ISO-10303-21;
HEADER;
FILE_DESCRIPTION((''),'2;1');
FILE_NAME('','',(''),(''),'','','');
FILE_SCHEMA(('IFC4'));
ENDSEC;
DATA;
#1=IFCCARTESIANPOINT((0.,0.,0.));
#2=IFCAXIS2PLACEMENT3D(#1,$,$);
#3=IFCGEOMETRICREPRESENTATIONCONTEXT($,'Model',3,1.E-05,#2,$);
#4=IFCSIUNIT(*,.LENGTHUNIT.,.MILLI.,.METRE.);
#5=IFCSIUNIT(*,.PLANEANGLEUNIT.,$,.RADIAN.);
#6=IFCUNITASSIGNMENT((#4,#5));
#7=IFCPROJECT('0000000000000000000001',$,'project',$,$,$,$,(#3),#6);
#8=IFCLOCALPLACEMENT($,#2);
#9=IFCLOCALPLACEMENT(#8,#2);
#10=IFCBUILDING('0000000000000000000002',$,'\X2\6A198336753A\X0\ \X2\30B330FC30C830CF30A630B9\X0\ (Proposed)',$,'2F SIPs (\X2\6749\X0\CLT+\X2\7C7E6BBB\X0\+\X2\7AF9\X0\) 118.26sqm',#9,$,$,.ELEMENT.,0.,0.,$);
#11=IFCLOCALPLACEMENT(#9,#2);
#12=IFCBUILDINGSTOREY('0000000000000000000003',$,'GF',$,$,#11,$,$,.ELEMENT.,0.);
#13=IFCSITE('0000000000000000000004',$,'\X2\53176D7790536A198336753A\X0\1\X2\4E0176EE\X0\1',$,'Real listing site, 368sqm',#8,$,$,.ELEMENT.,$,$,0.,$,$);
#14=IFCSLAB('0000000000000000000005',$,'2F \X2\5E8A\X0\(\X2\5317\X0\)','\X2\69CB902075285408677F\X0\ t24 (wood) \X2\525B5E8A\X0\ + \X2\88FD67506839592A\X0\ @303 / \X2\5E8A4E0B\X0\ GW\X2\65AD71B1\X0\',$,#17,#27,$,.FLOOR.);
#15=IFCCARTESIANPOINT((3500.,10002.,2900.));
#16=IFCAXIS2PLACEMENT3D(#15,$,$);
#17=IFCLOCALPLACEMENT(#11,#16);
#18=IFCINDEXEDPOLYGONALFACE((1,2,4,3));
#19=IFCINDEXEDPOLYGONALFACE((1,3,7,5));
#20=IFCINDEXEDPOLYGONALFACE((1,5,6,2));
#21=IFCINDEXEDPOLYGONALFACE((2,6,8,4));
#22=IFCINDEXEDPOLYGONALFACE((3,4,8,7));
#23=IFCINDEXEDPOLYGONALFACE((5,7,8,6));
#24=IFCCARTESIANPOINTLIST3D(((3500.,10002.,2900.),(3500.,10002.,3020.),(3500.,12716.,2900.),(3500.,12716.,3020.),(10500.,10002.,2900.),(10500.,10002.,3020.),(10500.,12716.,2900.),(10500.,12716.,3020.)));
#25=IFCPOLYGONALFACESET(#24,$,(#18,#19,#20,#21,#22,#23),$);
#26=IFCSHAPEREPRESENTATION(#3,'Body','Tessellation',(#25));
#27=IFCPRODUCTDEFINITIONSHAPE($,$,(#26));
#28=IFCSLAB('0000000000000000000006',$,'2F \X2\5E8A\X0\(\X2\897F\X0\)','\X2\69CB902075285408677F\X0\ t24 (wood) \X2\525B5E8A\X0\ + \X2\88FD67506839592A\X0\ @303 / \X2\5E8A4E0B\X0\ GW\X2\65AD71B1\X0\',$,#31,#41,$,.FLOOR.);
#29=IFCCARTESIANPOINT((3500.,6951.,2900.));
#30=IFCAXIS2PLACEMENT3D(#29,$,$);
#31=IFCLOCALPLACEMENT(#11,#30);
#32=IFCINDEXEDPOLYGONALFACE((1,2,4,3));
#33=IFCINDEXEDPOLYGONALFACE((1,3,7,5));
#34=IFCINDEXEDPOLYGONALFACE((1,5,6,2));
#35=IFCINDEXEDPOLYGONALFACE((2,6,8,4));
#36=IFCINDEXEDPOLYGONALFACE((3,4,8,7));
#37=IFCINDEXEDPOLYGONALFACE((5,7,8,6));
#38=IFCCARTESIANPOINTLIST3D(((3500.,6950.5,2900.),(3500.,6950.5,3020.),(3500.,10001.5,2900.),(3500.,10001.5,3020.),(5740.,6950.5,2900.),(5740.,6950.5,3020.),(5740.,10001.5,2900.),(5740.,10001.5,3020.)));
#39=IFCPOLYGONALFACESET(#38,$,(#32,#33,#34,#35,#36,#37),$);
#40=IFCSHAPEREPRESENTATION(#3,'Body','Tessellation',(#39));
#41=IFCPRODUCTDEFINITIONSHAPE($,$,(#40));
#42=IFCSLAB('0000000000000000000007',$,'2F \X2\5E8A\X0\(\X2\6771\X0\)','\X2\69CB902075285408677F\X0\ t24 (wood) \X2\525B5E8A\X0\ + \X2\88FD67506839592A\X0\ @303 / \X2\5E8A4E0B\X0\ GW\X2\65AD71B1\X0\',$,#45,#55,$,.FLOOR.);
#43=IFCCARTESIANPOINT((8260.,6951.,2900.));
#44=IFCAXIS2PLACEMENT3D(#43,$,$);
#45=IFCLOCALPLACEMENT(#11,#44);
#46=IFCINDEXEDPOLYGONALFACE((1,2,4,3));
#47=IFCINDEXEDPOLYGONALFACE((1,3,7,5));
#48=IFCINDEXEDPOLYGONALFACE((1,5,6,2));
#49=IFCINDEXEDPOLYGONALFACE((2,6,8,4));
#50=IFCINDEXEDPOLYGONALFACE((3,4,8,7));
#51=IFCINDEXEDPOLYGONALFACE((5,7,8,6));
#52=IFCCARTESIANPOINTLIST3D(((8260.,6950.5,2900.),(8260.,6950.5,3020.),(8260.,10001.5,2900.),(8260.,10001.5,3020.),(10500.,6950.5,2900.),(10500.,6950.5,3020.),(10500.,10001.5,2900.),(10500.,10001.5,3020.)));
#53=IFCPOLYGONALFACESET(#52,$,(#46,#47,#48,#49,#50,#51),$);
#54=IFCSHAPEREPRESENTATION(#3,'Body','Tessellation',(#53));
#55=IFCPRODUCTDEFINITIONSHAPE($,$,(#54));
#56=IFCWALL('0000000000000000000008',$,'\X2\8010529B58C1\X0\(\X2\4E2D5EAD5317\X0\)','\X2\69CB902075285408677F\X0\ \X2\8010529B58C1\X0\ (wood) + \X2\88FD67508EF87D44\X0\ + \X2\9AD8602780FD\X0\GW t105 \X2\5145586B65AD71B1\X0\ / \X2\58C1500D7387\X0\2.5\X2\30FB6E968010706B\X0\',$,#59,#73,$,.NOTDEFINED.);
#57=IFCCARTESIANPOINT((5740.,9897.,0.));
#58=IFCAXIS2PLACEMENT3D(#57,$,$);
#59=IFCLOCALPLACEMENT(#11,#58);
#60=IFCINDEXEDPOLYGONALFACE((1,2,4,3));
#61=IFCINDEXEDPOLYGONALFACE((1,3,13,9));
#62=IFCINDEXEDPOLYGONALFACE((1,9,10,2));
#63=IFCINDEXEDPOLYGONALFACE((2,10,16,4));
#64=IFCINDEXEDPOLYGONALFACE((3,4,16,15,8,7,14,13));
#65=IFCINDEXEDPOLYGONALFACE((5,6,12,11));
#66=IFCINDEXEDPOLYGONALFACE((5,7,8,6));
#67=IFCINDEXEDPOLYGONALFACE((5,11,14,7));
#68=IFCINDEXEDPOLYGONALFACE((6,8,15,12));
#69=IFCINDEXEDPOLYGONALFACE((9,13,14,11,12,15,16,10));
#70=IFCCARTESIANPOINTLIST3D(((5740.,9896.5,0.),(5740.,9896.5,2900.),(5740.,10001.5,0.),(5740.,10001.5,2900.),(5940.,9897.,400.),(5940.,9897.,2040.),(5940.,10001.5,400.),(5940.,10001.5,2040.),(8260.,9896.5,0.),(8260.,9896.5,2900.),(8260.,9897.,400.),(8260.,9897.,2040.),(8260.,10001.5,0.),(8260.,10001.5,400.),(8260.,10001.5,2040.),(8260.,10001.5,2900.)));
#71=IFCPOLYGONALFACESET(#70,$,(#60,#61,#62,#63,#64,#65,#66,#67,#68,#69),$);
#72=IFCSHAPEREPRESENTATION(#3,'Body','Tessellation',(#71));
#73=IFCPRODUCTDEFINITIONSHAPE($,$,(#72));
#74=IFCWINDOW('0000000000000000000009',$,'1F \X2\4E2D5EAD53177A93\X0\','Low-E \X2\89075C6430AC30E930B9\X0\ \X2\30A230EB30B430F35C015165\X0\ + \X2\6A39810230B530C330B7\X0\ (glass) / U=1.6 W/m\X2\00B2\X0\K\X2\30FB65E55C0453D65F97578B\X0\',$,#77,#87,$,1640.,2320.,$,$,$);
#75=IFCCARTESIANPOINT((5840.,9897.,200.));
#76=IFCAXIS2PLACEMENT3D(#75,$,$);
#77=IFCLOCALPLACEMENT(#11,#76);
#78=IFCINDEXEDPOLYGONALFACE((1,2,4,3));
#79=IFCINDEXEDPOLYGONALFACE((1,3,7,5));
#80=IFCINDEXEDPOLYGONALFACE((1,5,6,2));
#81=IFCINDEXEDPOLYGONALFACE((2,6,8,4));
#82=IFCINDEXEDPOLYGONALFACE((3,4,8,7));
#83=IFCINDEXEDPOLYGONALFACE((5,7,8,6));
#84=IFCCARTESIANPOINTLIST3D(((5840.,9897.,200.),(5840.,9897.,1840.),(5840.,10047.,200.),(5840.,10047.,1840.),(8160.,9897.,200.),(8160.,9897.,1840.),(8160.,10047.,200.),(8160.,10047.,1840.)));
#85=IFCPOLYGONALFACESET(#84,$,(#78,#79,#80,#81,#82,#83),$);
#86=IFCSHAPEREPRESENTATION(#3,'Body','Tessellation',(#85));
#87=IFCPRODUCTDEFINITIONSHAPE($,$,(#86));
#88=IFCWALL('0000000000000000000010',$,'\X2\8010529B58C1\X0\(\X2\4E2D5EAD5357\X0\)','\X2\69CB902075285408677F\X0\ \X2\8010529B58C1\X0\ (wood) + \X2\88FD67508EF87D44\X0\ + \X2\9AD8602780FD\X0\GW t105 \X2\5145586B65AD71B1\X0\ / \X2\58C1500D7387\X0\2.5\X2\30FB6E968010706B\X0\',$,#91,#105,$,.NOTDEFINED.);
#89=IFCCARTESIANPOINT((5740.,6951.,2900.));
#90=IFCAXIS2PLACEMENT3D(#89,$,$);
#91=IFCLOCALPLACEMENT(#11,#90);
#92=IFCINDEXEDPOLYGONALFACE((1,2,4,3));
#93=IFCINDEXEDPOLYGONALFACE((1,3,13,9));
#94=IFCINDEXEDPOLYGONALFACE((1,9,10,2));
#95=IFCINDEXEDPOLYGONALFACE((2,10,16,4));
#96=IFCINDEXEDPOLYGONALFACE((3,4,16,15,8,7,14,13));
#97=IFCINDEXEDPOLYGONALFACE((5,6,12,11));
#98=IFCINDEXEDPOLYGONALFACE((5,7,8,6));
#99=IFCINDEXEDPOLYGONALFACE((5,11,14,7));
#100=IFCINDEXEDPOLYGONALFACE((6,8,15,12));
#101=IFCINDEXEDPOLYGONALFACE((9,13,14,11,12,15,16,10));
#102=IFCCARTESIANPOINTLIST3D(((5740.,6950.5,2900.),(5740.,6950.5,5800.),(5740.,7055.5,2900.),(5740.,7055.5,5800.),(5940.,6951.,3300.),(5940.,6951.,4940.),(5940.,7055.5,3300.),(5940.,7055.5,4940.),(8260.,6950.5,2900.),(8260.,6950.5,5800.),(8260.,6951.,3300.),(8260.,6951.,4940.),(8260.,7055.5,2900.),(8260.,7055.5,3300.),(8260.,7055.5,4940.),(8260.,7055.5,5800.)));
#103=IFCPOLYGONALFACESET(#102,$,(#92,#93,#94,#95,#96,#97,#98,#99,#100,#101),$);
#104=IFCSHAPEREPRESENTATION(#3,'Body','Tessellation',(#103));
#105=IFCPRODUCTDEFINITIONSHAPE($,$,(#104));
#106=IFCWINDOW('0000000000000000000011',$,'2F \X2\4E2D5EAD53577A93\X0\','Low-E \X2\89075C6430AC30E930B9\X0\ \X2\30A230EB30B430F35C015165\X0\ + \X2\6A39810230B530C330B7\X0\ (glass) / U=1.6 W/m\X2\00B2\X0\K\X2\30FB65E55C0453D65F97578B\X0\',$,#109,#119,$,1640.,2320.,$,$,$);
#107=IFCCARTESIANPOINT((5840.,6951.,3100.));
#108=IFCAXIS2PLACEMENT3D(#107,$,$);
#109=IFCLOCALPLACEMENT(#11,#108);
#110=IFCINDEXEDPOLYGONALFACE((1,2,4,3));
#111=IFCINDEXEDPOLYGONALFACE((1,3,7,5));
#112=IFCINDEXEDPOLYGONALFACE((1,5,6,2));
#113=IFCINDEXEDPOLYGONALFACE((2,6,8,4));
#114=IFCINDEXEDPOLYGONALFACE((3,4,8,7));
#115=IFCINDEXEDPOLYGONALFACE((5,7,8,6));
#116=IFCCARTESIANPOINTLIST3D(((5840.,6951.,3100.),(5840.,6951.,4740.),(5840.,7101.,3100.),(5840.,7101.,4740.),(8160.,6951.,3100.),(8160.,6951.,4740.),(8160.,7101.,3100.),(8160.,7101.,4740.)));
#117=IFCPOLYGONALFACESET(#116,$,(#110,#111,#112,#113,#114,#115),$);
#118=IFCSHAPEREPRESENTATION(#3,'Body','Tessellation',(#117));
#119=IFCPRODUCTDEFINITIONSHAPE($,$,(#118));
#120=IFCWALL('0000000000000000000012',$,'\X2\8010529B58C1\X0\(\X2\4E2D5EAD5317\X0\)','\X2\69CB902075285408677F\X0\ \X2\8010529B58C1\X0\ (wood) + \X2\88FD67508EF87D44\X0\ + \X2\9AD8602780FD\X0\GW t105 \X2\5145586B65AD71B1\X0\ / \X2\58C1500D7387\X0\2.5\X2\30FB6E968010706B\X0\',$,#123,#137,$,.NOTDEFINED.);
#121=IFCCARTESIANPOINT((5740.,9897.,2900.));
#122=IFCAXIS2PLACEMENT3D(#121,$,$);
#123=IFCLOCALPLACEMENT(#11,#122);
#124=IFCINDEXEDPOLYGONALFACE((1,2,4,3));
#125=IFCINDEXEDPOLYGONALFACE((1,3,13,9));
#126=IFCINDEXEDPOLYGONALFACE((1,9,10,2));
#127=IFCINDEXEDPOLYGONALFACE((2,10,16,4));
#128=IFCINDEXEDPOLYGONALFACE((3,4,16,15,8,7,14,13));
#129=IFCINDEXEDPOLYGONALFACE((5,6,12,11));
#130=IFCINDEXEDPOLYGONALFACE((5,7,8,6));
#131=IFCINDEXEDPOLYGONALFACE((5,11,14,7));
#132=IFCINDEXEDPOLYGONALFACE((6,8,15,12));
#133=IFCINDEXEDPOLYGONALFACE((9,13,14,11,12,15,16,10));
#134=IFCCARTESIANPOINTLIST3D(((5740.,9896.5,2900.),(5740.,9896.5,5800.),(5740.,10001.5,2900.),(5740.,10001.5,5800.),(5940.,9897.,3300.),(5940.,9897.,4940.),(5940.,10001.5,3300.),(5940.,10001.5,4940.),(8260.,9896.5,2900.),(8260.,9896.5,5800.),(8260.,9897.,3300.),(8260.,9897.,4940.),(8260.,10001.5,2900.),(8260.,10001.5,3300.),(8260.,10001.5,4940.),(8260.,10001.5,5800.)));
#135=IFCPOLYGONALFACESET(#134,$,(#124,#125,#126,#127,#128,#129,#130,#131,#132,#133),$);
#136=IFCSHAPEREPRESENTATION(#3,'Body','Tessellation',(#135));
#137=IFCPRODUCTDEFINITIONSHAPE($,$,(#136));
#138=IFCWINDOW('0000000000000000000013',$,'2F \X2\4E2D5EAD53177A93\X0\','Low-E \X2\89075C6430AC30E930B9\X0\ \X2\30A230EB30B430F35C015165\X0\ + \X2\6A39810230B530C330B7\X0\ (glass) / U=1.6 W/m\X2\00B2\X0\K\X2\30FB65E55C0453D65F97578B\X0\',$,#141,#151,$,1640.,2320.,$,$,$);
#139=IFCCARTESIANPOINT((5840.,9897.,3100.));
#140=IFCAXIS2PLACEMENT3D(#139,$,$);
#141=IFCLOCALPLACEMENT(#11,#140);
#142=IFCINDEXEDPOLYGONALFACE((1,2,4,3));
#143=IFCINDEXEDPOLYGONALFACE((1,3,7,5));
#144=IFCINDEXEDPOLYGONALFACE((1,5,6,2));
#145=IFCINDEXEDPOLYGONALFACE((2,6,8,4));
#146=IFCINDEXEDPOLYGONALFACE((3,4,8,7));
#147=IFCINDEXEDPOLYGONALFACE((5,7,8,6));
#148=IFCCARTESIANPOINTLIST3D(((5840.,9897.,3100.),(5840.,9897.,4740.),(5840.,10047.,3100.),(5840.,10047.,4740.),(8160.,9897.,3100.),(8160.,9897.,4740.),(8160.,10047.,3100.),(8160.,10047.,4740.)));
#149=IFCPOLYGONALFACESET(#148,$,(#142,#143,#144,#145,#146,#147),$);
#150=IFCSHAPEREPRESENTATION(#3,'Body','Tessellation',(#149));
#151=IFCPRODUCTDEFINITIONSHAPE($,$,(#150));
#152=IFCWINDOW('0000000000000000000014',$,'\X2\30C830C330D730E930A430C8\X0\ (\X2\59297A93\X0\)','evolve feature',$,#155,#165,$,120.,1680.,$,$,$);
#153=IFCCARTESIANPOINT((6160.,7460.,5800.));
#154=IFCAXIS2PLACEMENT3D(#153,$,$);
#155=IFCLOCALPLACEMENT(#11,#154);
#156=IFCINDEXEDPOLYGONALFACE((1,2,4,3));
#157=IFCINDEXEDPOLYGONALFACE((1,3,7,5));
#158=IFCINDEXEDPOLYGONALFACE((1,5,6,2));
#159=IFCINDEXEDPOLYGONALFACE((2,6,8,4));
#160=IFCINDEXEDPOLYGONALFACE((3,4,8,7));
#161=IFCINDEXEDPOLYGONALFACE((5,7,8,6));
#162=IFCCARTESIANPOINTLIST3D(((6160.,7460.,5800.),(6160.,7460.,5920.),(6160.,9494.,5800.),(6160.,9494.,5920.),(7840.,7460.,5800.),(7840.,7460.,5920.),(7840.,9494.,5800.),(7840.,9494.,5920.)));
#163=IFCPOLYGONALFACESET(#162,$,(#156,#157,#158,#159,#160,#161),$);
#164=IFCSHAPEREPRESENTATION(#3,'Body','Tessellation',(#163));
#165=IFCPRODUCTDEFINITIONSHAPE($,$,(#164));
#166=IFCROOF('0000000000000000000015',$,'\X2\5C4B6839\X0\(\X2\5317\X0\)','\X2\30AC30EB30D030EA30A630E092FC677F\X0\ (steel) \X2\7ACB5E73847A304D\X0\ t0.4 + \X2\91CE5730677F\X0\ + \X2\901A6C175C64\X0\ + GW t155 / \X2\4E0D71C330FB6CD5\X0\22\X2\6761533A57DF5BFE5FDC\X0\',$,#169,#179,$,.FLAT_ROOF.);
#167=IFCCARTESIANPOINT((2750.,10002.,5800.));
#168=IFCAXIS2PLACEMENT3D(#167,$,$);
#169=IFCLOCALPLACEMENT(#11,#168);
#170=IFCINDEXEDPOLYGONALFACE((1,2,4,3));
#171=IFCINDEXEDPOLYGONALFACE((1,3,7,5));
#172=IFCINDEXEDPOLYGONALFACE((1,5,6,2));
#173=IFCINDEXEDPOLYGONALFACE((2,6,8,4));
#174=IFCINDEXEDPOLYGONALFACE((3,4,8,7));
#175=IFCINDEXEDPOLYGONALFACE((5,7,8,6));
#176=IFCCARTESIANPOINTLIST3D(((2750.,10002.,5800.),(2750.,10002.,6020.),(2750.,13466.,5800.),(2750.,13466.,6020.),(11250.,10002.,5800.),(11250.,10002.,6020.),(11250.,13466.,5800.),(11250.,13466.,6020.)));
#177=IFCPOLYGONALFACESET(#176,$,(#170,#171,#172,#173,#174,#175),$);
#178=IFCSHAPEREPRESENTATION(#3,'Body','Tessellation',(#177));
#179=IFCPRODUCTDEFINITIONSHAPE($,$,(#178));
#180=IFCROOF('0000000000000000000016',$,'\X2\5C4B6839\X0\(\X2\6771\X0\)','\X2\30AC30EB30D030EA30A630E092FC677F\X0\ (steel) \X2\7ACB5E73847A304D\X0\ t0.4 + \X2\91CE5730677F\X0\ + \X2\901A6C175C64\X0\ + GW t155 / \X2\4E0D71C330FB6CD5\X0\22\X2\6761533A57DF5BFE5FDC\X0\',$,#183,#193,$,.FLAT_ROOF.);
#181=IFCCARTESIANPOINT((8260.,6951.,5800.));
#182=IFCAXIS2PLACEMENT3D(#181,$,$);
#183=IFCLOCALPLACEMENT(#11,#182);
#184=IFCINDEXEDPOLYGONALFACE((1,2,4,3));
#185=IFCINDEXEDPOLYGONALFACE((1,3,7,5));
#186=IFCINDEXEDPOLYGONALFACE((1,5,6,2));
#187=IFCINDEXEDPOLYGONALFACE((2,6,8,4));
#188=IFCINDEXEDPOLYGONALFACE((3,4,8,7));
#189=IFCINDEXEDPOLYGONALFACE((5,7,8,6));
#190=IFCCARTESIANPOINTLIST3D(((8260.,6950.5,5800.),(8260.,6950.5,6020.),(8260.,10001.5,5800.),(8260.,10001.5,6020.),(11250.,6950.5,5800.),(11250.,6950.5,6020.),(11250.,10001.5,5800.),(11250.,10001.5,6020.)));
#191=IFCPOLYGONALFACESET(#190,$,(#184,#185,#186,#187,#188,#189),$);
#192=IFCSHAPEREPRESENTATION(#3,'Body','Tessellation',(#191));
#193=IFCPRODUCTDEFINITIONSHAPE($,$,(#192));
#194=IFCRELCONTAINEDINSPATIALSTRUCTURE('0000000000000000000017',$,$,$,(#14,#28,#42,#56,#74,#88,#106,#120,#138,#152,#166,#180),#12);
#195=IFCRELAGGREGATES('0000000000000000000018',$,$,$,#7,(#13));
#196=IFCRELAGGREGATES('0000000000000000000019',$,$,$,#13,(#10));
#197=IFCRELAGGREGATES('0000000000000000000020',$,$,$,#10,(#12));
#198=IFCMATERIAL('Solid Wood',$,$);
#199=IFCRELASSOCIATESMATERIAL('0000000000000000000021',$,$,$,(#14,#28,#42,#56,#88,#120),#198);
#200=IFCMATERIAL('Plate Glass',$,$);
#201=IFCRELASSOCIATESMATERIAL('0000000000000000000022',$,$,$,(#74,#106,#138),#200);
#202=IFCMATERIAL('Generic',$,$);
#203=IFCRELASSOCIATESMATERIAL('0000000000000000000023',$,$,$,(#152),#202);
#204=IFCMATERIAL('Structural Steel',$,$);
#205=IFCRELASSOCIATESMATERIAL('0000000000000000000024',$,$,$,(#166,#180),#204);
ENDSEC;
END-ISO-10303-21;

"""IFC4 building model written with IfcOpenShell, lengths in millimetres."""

from ifc_helpers import new_model, si_unit, frame, frame_2d, origin, place, context, project, spatial, rectangle, extrude, material, element, fill, save


model = new_model("IFC4")

# Units and contexts
model_context = context("Model", 3, precision=1e-05, world=origin())
ifc_project = project(units=[si_unit("LENGTHUNIT", "METRE", prefix="MILLI"), si_unit("PLANEANGLEUNIT", "RADIAN")], contexts=[model_context])

# Site, building, storey
site_placement = place(None, origin())
site = spatial("IfcSite", under=ifc_project, at=site_placement, Name="北海道標茶町1丁目1", ObjectType="Real listing site, 368sqm", CompositionType="ELEMENT", RefElevation=0.0)
building_placement = place(site_placement, origin())
building = spatial("IfcBuilding", under=site, at=building_placement, Name="標茶町 コートハウス (Proposed)", ObjectType="2F SIPs (杉CLT+籾殻+竹) 118.26sqm", CompositionType="ELEMENT", ElevationOfRefHeight=0.0, ElevationOfTerrain=0.0)
storey_placement = place(building_placement, origin())
storey = spatial("IfcBuildingStorey", under=building, at=storey_placement, Name="GF", CompositionType="ELEMENT", Elevation=0.0)

# Slabs
ifc_material_1 = material(Name="Solid Wood")
slab_1_placement = place(storey_placement, frame((3500.0, 10002.0, 2900.0)))
element("IfcSlab", 1, at=slab_1_placement, inside=storey, material=ifc_material_1, Name="2F 床(北)", Description="構造用合板 t24 (wood) 剛床 + 製材根太 @303 / 床下 GW断熱", PredefinedType="FLOOR", context=model_context, shape_type="SweptSolid", body=[
    extrude(rectangle(XDim=7000.0, YDim=2714.0, at=frame_2d((3500.0, 1357.0))), frame((3500.0, 10002.0, 2900.0)), (0.0, 0.0, 1.0), 120.0),
])
slab_2_placement = place(storey_placement, frame((3500.0, 6951.0, 2900.0)))
element("IfcSlab", 2, at=slab_2_placement, inside=storey, material=ifc_material_1, Name="2F 床(西)", Description="構造用合板 t24 (wood) 剛床 + 製材根太 @303 / 床下 GW断熱", PredefinedType="FLOOR", context=model_context, shape_type="SweptSolid", body=[
    extrude(rectangle(XDim=2240.0, YDim=3051.0, at=frame_2d((1120.0, 1525.0))), frame((3500.0, 6951.0, 2900.0)), (0.0, 0.0, 1.0), 120.0),
])
slab_3_placement = place(storey_placement, frame((8260.0, 6951.0, 2900.0)))
element("IfcSlab", 3, at=slab_3_placement, inside=storey, material=ifc_material_1, Name="2F 床(東)", Description="構造用合板 t24 (wood) 剛床 + 製材根太 @303 / 床下 GW断熱", PredefinedType="FLOOR", context=model_context, shape_type="SweptSolid", body=[
    extrude(rectangle(XDim=2240.0, YDim=3051.0, at=frame_2d((1120.0, 1525.0))), frame((8260.0, 6951.0, 2900.0)), (0.0, 0.0, 1.0), 120.0),
])

# Wall, opening, window
wall_1_placement = place(storey_placement, frame((5740.0, 9897.0, 0.0)))
wall_1 = element("IfcWall", 4, at=wall_1_placement, inside=storey, material=ifc_material_1, Name="耐力壁(中庭北)", Description="構造用合板 耐力壁 (wood) + 製材軸組 + 高性能GW t105 充填断熱 / 壁倍率2.5・準耐火", PredefinedType="NOTDEFINED", context=model_context, shape_type="SweptSolid", body=[
    extrude(rectangle(XDim=2520.0, YDim=105.0, at=frame_2d((1260.0, 52.0))), frame((5740.0, 9897.0, 0.0)), (0.0, 0.0, 1.0), 2900.0),
])
opening_1_placement = place(storey_placement, frame((5840.0, 9897.0, 200.0)))
opening_1 = element("IfcOpeningElement", 5, at=opening_1_placement, cuts=wall_1, PredefinedType="NOTDEFINED", context=model_context, shape_type="SweptSolid", body=[
    extrude(rectangle(XDim=2320.0, YDim=150.0, at=frame_2d((1160.0, 75.0))), frame((5840.0, 9897.0, 200.0)), (0.0, 0.0, 1.0), 1640.0),
])
ifc_material_2 = material(Name="Plate Glass")
window_1_placement = place(storey_placement, frame((5840.0, 9897.0, 200.0)))
window_1 = element("IfcWindow", 6, at=window_1_placement, inside=storey, material=ifc_material_2, Name="1F 中庭北窓", Description="Low-E 複層ガラス アルゴン封入 + 樹脂サッシ (glass) / U=1.6 W/m²K・日射取得型", OverallHeight=1640.0, OverallWidth=2320.0, context=model_context, shape_type="SweptSolid", body=[
    extrude(rectangle(XDim=2320.0, YDim=150.0, at=frame_2d((1160.0, 75.0))), frame((5840.0, 9897.0, 200.0)), (0.0, 0.0, 1.0), 1640.0),
])
fill(opening_1, window_1)

# Walls, openings, windows
wall_2_placement = place(storey_placement, frame((5740.0, 6951.0, 2900.0)))
wall_2 = element("IfcWall", 7, at=wall_2_placement, inside=storey, material=ifc_material_1, Name="耐力壁(中庭南)", Description="構造用合板 耐力壁 (wood) + 製材軸組 + 高性能GW t105 充填断熱 / 壁倍率2.5・準耐火", PredefinedType="NOTDEFINED", context=model_context, shape_type="SweptSolid", body=[
    extrude(rectangle(XDim=2520.0, YDim=105.0, at=frame_2d((1260.0, 52.0))), frame((5740.0, 6951.0, 2900.0)), (0.0, 0.0, 1.0), 2900.0),
])
opening_2_placement = place(storey_placement, frame((5840.0, 6951.0, 3100.0)))
opening_2 = element("IfcOpeningElement", 8, at=opening_2_placement, cuts=wall_2, PredefinedType="NOTDEFINED", context=model_context, shape_type="SweptSolid", body=[
    extrude(rectangle(XDim=2320.0, YDim=150.0, at=frame_2d((1160.0, 75.0))), frame((5840.0, 6951.0, 3100.0)), (0.0, 0.0, 1.0), 1640.0),
])
window_2_placement = place(storey_placement, frame((5840.0, 6951.0, 3100.0)))
window_2 = element("IfcWindow", 9, at=window_2_placement, inside=storey, material=ifc_material_2, Name="2F 中庭南窓", Description="Low-E 複層ガラス アルゴン封入 + 樹脂サッシ (glass) / U=1.6 W/m²K・日射取得型", OverallHeight=1640.0, OverallWidth=2320.0, context=model_context, shape_type="SweptSolid", body=[
    extrude(rectangle(XDim=2320.0, YDim=150.0, at=frame_2d((1160.0, 75.0))), frame((5840.0, 6951.0, 3100.0)), (0.0, 0.0, 1.0), 1640.0),
])
fill(opening_2, window_2)
wall_3_placement = place(storey_placement, frame((5740.0, 9897.0, 2900.0)))
wall_3 = element("IfcWall", 10, at=wall_3_placement, inside=storey, material=ifc_material_1, Name="耐力壁(中庭北)", Description="構造用合板 耐力壁 (wood) + 製材軸組 + 高性能GW t105 充填断熱 / 壁倍率2.5・準耐火", PredefinedType="NOTDEFINED", context=model_context, shape_type="SweptSolid", body=[
    extrude(rectangle(XDim=2520.0, YDim=105.0, at=frame_2d((1260.0, 52.0))), frame((5740.0, 9897.0, 2900.0)), (0.0, 0.0, 1.0), 2900.0),
])
opening_3_placement = place(storey_placement, frame((5840.0, 9897.0, 3100.0)))
opening_3 = element("IfcOpeningElement", 11, at=opening_3_placement, cuts=wall_3, PredefinedType="NOTDEFINED", context=model_context, shape_type="SweptSolid", body=[
    extrude(rectangle(XDim=2320.0, YDim=150.0, at=frame_2d((1160.0, 75.0))), frame((5840.0, 9897.0, 3100.0)), (0.0, 0.0, 1.0), 1640.0),
])
window_3_placement = place(storey_placement, frame((5840.0, 9897.0, 3100.0)))
window_3 = element("IfcWindow", 12, at=window_3_placement, inside=storey, material=ifc_material_2, Name="2F 中庭北窓", Description="Low-E 複層ガラス アルゴン封入 + 樹脂サッシ (glass) / U=1.6 W/m²K・日射取得型", OverallHeight=1640.0, OverallWidth=2320.0, context=model_context, shape_type="SweptSolid", body=[
    extrude(rectangle(XDim=2320.0, YDim=150.0, at=frame_2d((1160.0, 75.0))), frame((5840.0, 9897.0, 3100.0)), (0.0, 0.0, 1.0), 1640.0),
])
fill(opening_3, window_3)

# Window
ifc_material_3 = material(Name="Generic")
window_4_placement = place(storey_placement, frame((6160.0, 7460.0, 5800.0)))
element("IfcWindow", 13, at=window_4_placement, inside=storey, material=ifc_material_3, Name="トップライト (天窓)", Description="evolve feature", OverallHeight=120.0, OverallWidth=1680.0, context=model_context, shape_type="SweptSolid", body=[
    extrude(rectangle(XDim=1680.0, YDim=2034.0, at=frame_2d((840.0, 1017.0))), frame((6160.0, 7460.0, 5800.0)), (0.0, 0.0, 1.0), 120.0),
])

# Roofs
ifc_material_4 = material(Name="Structural Steel")
roof_1_placement = place(storey_placement, frame((2750.0, 10002.0, 5800.0)))
element("IfcRoof", 14, at=roof_1_placement, inside=storey, material=ifc_material_4, Name="屋根(北)", Description="ガルバリウム鋼板 (steel) 立平葺き t0.4 + 野地板 + 通気層 + GW t155 / 不燃・法22条区域対応", PredefinedType="FLAT_ROOF", context=model_context, shape_type="SweptSolid", body=[
    extrude(rectangle(XDim=8500.0, YDim=3464.0, at=frame_2d((4250.0, 1732.0))), frame((2750.0, 10002.0, 5800.0)), (0.0, 0.0, 1.0), 220.0),
])
roof_2_placement = place(storey_placement, frame((8260.0, 6951.0, 5800.0)))
element("IfcRoof", 15, at=roof_2_placement, inside=storey, material=ifc_material_4, Name="屋根(東)", Description="ガルバリウム鋼板 (steel) 立平葺き t0.4 + 野地板 + 通気層 + GW t155 / 不燃・法22条区域対応", PredefinedType="FLAT_ROOF", context=model_context, shape_type="SweptSolid", body=[
    extrude(rectangle(XDim=2990.0, YDim=3051.0, at=frame_2d((1495.0, 1525.0))), frame((8260.0, 6951.0, 5800.0)), (0.0, 0.0, 1.0), 220.0),
])

save(model, "model.ifc")
